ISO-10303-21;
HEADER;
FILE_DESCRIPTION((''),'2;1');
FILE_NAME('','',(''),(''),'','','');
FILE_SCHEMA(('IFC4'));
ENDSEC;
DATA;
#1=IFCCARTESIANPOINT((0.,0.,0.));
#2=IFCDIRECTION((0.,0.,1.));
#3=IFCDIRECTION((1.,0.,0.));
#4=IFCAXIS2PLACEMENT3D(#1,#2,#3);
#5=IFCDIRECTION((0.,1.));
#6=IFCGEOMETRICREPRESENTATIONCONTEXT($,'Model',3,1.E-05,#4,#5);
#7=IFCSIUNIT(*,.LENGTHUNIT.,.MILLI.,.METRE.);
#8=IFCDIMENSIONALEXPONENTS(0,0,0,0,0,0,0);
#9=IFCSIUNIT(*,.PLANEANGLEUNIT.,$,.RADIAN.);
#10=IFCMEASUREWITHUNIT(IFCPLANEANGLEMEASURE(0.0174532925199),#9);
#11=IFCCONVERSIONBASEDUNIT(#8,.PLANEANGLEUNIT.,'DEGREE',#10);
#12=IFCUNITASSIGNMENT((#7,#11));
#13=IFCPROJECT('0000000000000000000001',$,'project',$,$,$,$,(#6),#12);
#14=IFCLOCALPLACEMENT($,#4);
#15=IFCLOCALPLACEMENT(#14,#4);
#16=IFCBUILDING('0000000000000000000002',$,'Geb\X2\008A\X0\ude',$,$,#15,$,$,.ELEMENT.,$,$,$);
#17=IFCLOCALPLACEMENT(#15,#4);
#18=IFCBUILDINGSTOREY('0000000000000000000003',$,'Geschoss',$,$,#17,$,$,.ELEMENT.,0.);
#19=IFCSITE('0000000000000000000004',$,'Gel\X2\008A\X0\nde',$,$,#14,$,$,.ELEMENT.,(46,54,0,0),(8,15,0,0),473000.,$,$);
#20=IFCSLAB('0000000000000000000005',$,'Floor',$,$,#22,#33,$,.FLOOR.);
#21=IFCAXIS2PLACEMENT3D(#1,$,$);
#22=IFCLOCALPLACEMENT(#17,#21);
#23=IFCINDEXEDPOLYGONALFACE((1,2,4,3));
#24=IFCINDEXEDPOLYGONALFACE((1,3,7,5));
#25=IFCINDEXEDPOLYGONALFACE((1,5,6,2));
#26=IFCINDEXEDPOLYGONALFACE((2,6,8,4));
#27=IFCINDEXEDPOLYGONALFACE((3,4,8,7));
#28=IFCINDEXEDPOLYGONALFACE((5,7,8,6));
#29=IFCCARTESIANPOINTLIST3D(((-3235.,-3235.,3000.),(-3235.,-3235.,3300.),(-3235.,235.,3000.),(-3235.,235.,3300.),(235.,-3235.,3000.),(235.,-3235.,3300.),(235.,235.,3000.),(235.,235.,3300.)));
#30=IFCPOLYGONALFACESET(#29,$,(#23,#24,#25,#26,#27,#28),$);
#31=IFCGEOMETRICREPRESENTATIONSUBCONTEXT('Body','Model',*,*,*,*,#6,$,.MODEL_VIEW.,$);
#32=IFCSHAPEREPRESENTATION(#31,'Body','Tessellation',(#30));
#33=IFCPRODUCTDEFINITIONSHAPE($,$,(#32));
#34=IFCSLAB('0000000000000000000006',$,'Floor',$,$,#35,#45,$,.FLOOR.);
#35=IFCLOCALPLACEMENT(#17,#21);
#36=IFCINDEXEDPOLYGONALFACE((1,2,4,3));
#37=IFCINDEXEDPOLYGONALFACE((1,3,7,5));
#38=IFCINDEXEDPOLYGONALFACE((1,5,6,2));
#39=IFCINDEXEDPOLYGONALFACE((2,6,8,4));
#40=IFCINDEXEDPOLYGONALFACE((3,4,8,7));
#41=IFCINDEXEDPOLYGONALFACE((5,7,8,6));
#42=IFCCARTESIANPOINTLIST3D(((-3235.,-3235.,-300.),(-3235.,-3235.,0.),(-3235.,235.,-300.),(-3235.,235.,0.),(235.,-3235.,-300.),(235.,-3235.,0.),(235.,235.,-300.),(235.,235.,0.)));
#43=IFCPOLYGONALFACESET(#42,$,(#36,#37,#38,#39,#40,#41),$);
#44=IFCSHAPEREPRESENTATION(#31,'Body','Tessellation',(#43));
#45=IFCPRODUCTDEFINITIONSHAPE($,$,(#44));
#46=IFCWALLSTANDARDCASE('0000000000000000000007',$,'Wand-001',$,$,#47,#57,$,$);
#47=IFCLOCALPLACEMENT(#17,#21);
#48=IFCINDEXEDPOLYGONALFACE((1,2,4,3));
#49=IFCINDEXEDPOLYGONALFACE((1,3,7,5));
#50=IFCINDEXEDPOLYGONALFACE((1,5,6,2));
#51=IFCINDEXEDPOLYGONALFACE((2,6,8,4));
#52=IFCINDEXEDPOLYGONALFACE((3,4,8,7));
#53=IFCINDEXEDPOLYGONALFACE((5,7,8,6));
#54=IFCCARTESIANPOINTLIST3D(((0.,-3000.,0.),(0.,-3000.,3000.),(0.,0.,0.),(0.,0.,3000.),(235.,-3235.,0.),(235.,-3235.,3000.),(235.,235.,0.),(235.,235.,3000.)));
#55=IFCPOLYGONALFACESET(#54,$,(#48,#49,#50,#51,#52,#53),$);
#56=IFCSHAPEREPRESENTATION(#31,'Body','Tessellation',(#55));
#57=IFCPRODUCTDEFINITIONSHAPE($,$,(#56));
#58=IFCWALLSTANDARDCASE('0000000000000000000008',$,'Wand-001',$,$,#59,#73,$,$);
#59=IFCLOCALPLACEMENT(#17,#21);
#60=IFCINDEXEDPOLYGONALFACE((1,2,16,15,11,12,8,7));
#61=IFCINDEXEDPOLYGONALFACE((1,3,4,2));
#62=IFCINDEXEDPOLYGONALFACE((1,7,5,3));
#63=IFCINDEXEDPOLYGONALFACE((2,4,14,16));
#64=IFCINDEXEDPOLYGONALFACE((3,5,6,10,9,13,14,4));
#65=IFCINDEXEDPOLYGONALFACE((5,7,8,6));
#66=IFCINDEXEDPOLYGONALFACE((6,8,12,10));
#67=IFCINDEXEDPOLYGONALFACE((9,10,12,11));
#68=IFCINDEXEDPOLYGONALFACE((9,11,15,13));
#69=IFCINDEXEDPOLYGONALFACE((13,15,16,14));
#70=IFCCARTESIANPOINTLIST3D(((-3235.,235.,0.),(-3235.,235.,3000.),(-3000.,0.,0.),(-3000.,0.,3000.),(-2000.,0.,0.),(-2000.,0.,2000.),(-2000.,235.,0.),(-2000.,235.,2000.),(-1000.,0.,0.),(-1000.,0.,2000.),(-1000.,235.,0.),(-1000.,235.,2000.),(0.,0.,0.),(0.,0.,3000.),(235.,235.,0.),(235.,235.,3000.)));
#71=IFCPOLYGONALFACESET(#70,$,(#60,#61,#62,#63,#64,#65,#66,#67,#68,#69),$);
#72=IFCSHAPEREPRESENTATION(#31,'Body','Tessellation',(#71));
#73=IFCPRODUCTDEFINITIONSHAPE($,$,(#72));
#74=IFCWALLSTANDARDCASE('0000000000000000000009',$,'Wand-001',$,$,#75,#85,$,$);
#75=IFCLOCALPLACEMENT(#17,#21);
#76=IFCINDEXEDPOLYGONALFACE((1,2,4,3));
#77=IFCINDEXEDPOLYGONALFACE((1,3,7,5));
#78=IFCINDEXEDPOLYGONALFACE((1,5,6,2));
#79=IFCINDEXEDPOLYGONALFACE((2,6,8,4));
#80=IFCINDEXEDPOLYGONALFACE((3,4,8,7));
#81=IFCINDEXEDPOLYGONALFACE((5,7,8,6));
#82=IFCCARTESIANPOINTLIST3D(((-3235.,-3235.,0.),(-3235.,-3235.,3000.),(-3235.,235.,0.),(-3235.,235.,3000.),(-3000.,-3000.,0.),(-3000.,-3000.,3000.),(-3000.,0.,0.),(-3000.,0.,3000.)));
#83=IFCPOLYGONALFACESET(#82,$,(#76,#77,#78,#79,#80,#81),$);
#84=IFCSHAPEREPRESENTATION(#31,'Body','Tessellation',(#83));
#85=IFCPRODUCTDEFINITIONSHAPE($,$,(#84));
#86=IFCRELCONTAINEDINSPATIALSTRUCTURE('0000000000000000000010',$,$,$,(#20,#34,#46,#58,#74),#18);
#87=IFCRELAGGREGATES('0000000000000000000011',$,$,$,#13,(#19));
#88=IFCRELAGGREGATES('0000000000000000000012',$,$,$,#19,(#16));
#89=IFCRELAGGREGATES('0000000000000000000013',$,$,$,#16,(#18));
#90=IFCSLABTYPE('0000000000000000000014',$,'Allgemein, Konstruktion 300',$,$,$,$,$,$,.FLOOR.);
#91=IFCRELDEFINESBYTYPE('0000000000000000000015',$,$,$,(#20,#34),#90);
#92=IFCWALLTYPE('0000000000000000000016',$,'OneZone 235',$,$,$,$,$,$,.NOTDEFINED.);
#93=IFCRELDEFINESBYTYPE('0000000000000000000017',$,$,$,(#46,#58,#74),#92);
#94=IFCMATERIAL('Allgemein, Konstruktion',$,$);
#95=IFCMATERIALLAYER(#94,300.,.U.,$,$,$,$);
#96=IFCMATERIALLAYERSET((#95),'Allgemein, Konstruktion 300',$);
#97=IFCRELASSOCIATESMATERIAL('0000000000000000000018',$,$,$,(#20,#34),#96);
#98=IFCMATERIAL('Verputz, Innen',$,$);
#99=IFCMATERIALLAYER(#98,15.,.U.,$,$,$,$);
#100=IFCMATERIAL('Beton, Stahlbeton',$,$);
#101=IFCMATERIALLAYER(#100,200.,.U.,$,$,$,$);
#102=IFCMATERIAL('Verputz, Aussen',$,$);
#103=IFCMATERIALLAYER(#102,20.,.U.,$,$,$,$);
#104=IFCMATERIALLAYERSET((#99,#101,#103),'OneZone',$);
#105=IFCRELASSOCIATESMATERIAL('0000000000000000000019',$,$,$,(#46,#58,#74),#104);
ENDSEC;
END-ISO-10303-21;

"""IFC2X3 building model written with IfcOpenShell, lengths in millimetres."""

from ifc_helpers import new_model, entity, si_unit, converted_unit, direction, frame, origin_with_axes, origin_2d_with_axis, place, context, subcontext, project, spatial, polyline, rectangle, outline, extrude, material, layer, layer_set, layer_usage, type_object, element, save


model = new_model("IFC2X3")

# Units and contexts
model_context = context("Model", 3, precision=1e-05, world=origin_with_axes(), true_north=direction((0.0, 1.0)))
body_context = subcontext(model_context, "Body", "Model", "MODEL_VIEW")
ifc_project = project(units=[si_unit("LENGTHUNIT", "METRE", prefix="MILLI"), converted_unit("PLANEANGLEUNIT", "DEGREE", entity("IfcPlaneAngleMeasure", 0.0174532925199), si_unit("PLANEANGLEUNIT", "RADIAN"), dimensions=[0, 0, 0, 0, 0, 0, 0])], contexts=[model_context])

# Site, building, storey
site_placement = place(None, origin_with_axes())
site = spatial("IfcSite", under=ifc_project, at=site_placement, Name="Gel\u008ande", CompositionType="ELEMENT", RefLatitude=(46, 54, 0, 0), RefLongitude=(8, 15, 0, 0), RefElevation=473000.0)
building_placement = place(site_placement, origin_with_axes())
building = spatial("IfcBuilding", under=site, at=building_placement, Name="Geb\u008aude", CompositionType="ELEMENT")
storey_placement = place(building_placement, origin_with_axes())
storey = spatial("IfcBuildingStorey", under=building, at=storey_placement, Name="Geschoss", CompositionType="ELEMENT", Elevation=0.0)

# Slabs
ifc_material_1 = material(Name="Allgemein, Konstruktion")
ifc_layer_1 = layer(ifc_material_1, 300.0, ventilated="UNKNOWN")
ifc_layer_set_1 = layer_set([ifc_layer_1], Name="Allgemein, Konstruktion 300")
ifc_layer_usage_1 = layer_usage(ifc_layer_set_1, "AXIS3", "NEGATIVE", 300.0)
slab_type = type_object("IfcSlabType", Name="Allgemein, Konstruktion 300", PredefinedType="FLOOR")
slab_1_placement = place(storey_placement, frame((-3235.0, -3235.0, 3300.0), z_axis=(0.0, 0.0, 1.0), x_axis=(1.0, 0.0, 0.0)))
element("IfcSlab", 1, at=slab_1_placement, inside=storey, type_object=slab_type, material=ifc_layer_usage_1, Name="Floor", PredefinedType="FLOOR", context=body_context, shape_type="SweptSolid", body=[
    extrude(outline(polyline([(0.0, 0.0), (3470.0, 0.0), (3470.0, 3470.0), (0.0, 3470.0), (0.0, 0.0)])), frame((0.0, 0.0, -300.0), z_axis=(0.0, 0.0, 1.0), x_axis=(1.0, 0.0, 0.0)), (0.0, 0.0, 1.0), 300.0),
])
ifc_layer_usage_2 = layer_usage(ifc_layer_set_1, "AXIS3", "NEGATIVE", 300.0)
slab_2_placement = place(storey_placement, frame((-3235.0, -3235.0, 0.0), z_axis=(0.0, 0.0, 1.0), x_axis=(1.0, 0.0, 0.0)))
element("IfcSlab", 2, at=slab_2_placement, inside=storey, type_object=slab_type, material=ifc_layer_usage_2, Name="Floor", PredefinedType="FLOOR", context=body_context, shape_type="SweptSolid", body=[
    extrude(outline(polyline([(0.0, 0.0), (3470.0, 0.0), (3470.0, 3470.0), (0.0, 3470.0), (0.0, 0.0)])), frame((0.0, 0.0, -300.0), z_axis=(0.0, 0.0, 1.0), x_axis=(1.0, 0.0, 0.0)), (0.0, 0.0, 1.0), 300.0),
])

# Wall
ifc_material_2 = material(Name="Verputz, Innen")
ifc_layer_2 = layer(ifc_material_2, 15.0, ventilated="UNKNOWN")
ifc_material_3 = material(Name="Beton, Stahlbeton")
ifc_layer_3 = layer(ifc_material_3, 200.0, ventilated="UNKNOWN")
ifc_material_4 = material(Name="Verputz, Aussen")
ifc_layer_4 = layer(ifc_material_4, 20.0, ventilated="UNKNOWN")
ifc_layer_set_2 = layer_set([ifc_layer_2, ifc_layer_3, ifc_layer_4], Name="OneZone")
ifc_layer_usage_3 = layer_usage(ifc_layer_set_2, "AXIS2", "POSITIVE", 0.0)
wall_type = type_object("IfcWallType", Name="OneZone 235", PredefinedType="NOTDEFINED")
wall_1_placement = place(storey_placement, frame((0.0, 235.0, 0.0), z_axis=(0.0, 0.0, 1.0), x_axis=(0.0, -1.0, 0.0)))
element("IfcWallStandardCase", 3, at=wall_1_placement, inside=storey, type_object=wall_type, material=ifc_layer_usage_3, Name="Wand-001", context=body_context, shape_type="SweptSolid", body=[
    extrude(outline(polyline([(235.0, 0.0), (3235.0, 0.0), (3470.0, 235.0), (0.0, 235.0), (235.0, 0.0)])), origin_with_axes(), (0.0, 0.0, 1.0), 3000.0),
])

# Wall, opening
ifc_layer_usage_4 = layer_usage(ifc_layer_set_2, "AXIS2", "NEGATIVE", 235.0)
wall_2_placement = place(storey_placement, frame((0.0, 235.0, 0.0), z_axis=(0.0, 0.0, 1.0), x_axis=(-1.0, 0.0, 0.0)))
wall_2 = element("IfcWallStandardCase", 4, at=wall_2_placement, inside=storey, type_object=wall_type, material=ifc_layer_usage_4, Name="Wand-001", context=body_context, shape_type="SweptSolid", body=[
    extrude(outline(polyline([(-235.0, 0.0), (3235.0, 0.0), (3000.0, 235.0), (0.0, 235.0), (-235.0, 0.0)])), origin_with_axes(), (0.0, 0.0, 1.0), 3000.0),
])
opening_1_placement = place(wall_2_placement, frame((1500.0, 0.0, 0.0), z_axis=(0.0, 0.0, 1.0), x_axis=(1.0, 0.0, 0.0)))
element("IfcOpeningElement", 5, at=opening_1_placement, cuts=wall_2, context=body_context, shape_type="SweptSolid", body=[
    extrude(rectangle(XDim=1000.0, YDim=2000.0, at=origin_2d_with_axis()), frame((0.0, -235.0, 1000.0), z_axis=(0.0, -1.0, 0.0), x_axis=(-1.0, 0.0, 0.0)), (0.0, 0.0, -1.0), 705.0),
])

# Wall
ifc_layer_usage_5 = layer_usage(ifc_layer_set_2, "AXIS2", "NEGATIVE", 0.0)
wall_3_placement = place(storey_placement, frame((-3000.0, 235.0, 0.0), z_axis=(0.0, 0.0, 1.0), x_axis=(0.0, -1.0, 0.0)))
element("IfcWallStandardCase", 6, at=wall_3_placement, inside=storey, type_object=wall_type, material=ifc_layer_usage_5, Name="Wand-001", context=body_context, shape_type="SweptSolid", body=[
    extrude(outline(polyline([(0.0, -235.0), (3470.0, -235.0), (3235.0, 0.0), (235.0, 0.0), (0.0, -235.0)])), origin_with_axes(), (0.0, 0.0, 1.0), 3000.0),
])

save(model, "model.ifc")
